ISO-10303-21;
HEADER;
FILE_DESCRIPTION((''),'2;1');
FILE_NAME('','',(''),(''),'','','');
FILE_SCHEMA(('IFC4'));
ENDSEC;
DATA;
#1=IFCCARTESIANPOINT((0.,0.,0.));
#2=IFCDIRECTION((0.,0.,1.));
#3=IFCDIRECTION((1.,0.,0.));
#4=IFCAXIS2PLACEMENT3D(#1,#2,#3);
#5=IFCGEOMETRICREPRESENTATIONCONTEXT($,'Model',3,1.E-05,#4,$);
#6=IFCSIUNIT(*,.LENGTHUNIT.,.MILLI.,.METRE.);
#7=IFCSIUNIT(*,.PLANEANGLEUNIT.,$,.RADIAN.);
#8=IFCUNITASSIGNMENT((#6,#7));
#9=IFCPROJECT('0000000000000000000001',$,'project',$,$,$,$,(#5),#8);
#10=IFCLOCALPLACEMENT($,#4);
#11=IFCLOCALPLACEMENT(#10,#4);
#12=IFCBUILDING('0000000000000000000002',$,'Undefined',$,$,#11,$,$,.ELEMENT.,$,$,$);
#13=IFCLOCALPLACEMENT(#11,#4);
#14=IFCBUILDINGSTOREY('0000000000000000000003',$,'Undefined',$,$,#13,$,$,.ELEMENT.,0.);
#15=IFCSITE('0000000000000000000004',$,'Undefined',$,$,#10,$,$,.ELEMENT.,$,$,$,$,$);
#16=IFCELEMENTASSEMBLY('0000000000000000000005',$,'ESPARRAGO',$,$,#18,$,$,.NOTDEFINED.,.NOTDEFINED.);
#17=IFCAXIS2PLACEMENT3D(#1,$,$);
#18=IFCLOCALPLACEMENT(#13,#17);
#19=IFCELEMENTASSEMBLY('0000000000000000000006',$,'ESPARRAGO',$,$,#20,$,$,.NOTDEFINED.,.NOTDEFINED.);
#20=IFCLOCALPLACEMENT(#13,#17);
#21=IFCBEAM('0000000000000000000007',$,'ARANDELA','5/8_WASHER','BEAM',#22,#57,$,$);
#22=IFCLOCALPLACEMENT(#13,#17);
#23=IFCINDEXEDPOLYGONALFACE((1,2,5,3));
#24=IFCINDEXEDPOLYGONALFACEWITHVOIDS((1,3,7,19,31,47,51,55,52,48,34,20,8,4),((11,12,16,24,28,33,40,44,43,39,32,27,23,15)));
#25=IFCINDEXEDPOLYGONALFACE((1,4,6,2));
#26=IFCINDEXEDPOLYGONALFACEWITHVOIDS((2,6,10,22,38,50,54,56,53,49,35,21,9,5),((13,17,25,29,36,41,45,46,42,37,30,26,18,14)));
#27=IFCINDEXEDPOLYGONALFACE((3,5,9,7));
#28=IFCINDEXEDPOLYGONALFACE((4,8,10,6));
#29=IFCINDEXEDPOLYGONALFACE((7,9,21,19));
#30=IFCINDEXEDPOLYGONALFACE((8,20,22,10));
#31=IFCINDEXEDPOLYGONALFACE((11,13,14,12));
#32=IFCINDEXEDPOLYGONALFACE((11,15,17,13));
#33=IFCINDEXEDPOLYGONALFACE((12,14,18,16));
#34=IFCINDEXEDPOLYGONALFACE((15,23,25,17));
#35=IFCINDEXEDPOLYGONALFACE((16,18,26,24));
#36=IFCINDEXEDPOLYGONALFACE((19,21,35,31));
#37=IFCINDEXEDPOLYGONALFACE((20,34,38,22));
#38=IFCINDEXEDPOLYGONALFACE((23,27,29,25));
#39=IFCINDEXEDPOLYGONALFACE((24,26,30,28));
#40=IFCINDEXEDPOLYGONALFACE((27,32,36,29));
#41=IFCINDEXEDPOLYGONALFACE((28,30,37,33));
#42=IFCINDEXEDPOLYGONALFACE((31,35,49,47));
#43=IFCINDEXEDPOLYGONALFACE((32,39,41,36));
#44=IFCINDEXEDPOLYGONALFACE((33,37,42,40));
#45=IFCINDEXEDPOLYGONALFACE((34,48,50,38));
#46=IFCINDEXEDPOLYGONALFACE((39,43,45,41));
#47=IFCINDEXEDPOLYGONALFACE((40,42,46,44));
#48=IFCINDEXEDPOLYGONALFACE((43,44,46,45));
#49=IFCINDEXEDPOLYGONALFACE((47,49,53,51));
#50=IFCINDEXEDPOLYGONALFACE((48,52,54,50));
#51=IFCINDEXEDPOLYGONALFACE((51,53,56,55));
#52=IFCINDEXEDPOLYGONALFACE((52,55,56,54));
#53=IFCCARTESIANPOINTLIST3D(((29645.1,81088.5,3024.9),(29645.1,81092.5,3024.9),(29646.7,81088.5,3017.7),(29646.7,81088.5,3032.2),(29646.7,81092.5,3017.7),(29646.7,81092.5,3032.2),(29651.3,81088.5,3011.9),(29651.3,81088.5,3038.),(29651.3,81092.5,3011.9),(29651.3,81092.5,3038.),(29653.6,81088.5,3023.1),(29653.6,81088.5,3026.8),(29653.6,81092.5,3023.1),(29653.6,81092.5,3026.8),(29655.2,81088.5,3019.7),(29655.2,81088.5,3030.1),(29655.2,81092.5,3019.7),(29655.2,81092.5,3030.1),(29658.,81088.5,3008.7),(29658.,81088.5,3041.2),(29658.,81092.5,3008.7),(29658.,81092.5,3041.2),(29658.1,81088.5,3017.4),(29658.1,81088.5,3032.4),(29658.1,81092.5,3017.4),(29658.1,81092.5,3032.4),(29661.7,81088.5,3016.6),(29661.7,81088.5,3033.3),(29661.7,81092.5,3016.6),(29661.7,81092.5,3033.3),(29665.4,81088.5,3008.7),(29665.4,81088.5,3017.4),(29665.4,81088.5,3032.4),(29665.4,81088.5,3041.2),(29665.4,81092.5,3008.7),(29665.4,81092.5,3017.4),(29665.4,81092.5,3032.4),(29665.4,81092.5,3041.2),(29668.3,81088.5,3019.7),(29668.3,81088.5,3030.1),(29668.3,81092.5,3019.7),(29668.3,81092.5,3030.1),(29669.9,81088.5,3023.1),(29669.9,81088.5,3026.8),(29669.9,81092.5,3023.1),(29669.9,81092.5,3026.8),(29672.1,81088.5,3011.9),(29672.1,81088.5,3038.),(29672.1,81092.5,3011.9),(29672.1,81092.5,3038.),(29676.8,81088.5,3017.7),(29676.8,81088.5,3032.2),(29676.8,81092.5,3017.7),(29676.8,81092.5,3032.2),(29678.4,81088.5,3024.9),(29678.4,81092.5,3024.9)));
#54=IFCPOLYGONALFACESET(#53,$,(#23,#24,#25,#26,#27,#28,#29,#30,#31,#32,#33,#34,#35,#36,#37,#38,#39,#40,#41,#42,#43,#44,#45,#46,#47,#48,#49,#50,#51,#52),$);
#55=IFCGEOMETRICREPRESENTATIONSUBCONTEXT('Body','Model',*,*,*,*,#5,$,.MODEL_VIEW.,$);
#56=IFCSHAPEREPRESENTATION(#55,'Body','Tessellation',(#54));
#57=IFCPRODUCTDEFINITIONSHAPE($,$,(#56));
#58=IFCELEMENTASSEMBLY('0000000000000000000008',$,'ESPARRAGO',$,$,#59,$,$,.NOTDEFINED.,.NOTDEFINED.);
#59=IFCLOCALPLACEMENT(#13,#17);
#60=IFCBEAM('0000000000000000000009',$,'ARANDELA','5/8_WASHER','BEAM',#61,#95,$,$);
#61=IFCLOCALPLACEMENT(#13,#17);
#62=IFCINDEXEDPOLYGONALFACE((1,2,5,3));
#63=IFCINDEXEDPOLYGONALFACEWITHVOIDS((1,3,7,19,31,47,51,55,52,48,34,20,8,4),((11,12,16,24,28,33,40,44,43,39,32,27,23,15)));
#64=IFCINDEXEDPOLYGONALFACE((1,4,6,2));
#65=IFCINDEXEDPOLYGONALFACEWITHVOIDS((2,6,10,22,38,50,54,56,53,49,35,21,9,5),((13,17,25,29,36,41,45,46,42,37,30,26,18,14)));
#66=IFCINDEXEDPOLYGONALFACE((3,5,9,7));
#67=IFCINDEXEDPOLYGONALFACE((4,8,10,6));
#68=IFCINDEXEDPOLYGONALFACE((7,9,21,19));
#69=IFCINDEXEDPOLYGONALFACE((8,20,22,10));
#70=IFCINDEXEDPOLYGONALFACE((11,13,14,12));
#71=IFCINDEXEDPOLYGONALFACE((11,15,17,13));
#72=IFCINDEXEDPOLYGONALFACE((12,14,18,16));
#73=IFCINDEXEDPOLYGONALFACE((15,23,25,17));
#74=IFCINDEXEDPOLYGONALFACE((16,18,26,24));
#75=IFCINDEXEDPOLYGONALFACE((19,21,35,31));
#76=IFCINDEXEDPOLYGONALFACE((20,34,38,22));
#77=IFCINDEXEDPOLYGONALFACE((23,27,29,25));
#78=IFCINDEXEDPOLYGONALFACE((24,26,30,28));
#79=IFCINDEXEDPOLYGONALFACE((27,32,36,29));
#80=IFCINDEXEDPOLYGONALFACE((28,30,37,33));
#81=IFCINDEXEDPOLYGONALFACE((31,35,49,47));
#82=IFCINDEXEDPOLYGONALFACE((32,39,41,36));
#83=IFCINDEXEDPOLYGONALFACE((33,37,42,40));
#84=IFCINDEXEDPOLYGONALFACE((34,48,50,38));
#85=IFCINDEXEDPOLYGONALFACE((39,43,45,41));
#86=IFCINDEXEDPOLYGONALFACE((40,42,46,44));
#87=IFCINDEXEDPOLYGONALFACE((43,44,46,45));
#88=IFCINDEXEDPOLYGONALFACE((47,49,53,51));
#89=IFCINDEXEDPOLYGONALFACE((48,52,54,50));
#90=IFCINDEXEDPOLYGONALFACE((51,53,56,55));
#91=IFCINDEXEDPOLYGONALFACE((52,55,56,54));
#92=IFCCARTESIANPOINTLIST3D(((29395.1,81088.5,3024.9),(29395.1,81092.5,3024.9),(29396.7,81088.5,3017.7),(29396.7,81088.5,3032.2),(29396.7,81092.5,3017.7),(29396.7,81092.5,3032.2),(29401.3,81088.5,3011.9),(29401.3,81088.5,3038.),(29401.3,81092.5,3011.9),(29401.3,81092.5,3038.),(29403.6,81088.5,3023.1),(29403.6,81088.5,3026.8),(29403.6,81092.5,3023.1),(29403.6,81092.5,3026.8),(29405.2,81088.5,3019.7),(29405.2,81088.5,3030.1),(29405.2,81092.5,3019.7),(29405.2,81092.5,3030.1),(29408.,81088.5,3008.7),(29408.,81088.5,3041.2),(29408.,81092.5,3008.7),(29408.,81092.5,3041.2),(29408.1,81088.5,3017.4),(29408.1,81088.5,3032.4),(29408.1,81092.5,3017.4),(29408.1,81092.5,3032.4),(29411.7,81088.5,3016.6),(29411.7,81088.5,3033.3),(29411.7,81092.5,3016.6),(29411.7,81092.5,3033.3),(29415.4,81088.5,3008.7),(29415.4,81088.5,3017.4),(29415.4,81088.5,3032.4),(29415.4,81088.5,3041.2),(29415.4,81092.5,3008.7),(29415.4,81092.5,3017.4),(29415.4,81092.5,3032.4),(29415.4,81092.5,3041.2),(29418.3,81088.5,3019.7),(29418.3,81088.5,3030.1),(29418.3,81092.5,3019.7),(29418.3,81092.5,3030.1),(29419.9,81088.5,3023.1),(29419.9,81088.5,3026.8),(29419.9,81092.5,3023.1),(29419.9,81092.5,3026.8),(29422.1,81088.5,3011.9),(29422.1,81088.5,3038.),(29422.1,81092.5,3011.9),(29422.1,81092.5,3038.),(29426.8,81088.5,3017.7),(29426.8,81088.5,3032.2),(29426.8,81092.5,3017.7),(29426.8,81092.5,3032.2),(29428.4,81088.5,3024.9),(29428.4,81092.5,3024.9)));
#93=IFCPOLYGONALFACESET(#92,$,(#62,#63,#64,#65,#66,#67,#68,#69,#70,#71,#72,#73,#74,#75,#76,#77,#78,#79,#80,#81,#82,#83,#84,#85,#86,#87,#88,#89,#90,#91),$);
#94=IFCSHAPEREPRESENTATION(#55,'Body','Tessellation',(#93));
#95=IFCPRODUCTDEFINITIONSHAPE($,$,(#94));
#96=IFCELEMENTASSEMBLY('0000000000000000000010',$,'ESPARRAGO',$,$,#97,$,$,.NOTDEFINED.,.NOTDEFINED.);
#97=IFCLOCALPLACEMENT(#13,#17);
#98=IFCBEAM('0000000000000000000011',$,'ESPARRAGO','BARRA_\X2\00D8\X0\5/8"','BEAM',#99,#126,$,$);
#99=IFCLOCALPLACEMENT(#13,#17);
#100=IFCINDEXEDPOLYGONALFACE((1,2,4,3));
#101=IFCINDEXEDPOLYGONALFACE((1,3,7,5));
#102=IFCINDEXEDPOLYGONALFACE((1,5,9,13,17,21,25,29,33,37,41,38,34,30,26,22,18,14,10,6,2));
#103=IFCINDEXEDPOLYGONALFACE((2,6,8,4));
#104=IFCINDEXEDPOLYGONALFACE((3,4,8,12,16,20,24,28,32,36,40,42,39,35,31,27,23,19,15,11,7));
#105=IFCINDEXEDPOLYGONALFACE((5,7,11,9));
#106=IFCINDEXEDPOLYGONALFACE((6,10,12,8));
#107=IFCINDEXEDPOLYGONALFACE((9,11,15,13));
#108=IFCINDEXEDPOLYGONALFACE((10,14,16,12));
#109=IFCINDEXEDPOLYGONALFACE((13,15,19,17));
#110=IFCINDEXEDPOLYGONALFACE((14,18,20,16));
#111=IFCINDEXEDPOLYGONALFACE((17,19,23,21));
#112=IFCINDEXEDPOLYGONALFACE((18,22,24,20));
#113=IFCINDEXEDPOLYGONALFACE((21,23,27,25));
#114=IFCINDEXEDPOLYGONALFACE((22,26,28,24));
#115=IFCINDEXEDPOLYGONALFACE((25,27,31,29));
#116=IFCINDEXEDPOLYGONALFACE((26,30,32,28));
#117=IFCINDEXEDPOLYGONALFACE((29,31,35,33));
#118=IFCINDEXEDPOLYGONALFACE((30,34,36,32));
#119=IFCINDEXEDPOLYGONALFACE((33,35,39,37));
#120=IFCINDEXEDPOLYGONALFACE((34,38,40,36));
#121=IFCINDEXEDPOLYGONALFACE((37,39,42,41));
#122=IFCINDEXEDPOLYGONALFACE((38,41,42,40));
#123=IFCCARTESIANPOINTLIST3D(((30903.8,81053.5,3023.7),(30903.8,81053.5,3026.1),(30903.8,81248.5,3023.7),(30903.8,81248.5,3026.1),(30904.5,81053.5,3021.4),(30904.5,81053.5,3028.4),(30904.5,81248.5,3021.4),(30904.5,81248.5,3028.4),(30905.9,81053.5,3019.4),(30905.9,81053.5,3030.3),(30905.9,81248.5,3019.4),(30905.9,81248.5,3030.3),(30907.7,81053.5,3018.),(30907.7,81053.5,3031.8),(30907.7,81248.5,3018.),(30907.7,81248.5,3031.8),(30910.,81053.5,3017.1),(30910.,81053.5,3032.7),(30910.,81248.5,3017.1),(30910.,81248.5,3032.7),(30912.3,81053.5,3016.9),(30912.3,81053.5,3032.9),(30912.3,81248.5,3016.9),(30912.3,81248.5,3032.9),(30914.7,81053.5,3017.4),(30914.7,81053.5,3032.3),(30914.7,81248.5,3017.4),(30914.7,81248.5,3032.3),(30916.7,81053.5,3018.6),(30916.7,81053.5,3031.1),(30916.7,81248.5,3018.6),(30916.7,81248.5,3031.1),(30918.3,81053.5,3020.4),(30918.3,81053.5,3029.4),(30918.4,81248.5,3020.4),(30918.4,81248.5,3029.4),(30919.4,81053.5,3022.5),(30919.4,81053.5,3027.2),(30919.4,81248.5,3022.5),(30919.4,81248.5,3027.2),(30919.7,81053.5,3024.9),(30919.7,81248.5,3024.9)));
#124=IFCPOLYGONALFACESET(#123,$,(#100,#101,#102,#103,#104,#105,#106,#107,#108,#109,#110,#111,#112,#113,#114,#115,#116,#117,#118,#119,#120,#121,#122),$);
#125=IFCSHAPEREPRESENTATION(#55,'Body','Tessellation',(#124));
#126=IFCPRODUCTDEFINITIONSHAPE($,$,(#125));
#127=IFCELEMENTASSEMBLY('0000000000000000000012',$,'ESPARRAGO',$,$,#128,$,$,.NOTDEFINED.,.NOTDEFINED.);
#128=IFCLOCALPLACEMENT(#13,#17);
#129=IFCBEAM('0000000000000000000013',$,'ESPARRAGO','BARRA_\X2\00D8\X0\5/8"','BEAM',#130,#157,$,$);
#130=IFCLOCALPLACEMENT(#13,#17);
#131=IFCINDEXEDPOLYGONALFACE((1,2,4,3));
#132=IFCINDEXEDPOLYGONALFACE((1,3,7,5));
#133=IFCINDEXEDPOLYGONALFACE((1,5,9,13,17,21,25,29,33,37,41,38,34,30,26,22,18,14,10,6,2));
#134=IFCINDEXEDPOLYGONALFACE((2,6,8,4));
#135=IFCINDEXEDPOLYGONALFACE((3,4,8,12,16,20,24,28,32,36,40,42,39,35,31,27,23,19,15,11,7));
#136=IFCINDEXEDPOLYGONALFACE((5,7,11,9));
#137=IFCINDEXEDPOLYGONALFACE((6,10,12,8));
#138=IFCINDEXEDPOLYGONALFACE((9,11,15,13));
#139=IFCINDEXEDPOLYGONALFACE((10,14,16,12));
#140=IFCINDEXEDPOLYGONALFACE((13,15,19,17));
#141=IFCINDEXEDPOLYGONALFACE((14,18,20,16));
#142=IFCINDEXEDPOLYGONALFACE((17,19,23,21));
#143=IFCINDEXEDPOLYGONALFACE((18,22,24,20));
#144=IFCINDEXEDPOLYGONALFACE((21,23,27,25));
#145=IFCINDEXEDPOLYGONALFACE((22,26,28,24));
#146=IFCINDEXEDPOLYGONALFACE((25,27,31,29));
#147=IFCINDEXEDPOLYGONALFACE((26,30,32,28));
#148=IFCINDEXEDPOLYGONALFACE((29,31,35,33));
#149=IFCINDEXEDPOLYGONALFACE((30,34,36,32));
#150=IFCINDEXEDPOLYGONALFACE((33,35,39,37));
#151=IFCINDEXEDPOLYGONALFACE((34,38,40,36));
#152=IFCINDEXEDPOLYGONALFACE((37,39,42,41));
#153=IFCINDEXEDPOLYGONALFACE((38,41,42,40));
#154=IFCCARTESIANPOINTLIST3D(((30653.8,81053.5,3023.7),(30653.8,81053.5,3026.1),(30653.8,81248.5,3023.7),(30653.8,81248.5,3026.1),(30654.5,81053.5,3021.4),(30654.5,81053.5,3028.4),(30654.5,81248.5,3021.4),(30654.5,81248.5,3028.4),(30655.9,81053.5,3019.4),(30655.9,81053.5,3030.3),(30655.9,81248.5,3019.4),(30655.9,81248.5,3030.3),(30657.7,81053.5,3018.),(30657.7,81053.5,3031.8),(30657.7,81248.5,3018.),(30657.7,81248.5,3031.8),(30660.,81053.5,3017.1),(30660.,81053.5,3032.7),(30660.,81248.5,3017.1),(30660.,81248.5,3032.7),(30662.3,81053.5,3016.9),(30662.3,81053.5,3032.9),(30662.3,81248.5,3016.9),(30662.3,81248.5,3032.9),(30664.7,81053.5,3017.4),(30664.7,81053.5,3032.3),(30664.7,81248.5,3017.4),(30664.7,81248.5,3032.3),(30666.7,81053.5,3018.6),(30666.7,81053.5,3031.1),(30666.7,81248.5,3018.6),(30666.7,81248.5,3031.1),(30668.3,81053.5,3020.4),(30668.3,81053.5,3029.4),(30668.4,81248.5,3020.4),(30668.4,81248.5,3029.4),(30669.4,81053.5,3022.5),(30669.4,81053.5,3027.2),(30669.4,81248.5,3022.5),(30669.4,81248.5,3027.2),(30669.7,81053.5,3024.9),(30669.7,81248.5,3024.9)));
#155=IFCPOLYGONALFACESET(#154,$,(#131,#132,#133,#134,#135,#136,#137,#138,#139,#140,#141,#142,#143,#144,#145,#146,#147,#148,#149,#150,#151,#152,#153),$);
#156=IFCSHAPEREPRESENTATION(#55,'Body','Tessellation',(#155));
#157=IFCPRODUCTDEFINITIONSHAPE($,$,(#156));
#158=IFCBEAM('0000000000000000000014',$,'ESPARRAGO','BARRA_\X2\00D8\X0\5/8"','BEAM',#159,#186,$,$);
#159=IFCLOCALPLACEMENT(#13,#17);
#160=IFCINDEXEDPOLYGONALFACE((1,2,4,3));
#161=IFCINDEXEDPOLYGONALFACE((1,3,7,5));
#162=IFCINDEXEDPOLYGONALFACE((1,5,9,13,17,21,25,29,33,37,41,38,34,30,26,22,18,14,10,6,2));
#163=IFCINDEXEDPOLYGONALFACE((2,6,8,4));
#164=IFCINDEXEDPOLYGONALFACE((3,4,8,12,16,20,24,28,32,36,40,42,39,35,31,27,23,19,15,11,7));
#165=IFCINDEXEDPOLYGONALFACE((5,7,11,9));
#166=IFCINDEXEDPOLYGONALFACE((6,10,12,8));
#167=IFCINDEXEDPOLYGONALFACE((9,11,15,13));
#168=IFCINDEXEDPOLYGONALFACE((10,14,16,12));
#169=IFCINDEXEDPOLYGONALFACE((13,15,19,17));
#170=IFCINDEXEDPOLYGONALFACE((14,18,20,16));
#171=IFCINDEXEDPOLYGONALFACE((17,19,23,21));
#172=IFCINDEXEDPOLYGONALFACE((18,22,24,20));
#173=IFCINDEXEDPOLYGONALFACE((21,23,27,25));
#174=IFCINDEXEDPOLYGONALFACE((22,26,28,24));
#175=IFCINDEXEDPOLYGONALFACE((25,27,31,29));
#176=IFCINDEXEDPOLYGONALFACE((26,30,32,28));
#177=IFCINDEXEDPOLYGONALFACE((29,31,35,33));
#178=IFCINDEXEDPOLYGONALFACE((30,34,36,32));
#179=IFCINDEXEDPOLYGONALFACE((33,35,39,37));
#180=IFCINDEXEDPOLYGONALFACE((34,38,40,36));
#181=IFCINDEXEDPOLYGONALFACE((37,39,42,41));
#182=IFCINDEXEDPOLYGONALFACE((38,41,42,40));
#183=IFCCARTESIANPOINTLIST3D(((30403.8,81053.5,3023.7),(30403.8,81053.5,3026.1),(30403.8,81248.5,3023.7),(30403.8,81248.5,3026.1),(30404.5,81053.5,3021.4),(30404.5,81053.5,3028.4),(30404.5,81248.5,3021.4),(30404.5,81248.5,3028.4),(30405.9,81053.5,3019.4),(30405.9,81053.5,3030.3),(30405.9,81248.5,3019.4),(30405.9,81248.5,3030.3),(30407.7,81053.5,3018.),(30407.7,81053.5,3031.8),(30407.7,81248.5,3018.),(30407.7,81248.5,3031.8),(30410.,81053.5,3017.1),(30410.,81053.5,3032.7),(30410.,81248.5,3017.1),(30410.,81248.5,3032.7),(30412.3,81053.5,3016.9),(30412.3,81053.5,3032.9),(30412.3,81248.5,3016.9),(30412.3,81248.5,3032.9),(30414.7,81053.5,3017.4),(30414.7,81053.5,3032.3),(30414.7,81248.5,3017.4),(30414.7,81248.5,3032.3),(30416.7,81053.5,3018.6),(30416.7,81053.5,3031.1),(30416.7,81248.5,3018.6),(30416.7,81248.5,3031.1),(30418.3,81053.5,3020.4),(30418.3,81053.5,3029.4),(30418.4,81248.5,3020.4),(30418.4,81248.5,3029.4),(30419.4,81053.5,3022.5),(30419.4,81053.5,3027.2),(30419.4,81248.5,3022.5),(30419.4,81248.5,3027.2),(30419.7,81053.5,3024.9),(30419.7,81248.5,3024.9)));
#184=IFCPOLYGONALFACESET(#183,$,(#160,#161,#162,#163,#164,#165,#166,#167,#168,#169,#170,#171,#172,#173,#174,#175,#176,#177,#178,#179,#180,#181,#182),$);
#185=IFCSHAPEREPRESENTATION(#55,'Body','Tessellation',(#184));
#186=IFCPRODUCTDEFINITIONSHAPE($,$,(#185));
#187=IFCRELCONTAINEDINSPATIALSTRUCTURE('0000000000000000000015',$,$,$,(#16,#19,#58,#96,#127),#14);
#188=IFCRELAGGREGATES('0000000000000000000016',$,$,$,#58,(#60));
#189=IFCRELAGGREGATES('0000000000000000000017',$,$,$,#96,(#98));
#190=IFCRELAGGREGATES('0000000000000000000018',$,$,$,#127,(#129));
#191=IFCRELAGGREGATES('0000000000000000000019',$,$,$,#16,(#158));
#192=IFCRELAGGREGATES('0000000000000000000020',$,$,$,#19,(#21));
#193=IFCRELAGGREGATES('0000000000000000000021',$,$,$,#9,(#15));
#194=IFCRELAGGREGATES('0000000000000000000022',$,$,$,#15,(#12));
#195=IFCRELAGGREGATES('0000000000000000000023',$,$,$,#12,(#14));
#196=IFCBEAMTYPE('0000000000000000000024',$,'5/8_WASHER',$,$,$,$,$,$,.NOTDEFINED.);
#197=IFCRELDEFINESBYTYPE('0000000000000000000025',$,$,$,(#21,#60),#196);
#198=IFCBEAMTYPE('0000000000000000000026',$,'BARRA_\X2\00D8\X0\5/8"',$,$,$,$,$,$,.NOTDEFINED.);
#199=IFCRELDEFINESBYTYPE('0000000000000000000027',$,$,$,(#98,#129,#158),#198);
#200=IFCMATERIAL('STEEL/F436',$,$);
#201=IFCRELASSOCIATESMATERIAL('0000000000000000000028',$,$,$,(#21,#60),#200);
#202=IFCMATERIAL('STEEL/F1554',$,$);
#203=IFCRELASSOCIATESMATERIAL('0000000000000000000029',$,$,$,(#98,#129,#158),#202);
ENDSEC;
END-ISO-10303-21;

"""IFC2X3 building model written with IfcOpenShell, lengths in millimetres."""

from ifc_helpers import new_model, si_unit, frame, origin_with_axes, origin_2d_with_axis, place, context, subcontext, project, spatial, polyline, circle, outline, extrude, material, type_object, element, aggregate, save


model = new_model("IFC2X3")

# Units and contexts
model_context = context("Model", 3, precision=1e-05, world=origin_with_axes())
body_context = subcontext(model_context, "Body", "Model", "MODEL_VIEW")
ifc_project = project(units=[si_unit("LENGTHUNIT", "METRE", prefix="MILLI"), si_unit("PLANEANGLEUNIT", "RADIAN")], contexts=[model_context])

# Site, building, storey
site_placement = place(None, origin_with_axes())
site = spatial("IfcSite", under=ifc_project, at=site_placement, Name="Undefined", CompositionType="ELEMENT")
building_placement = place(site_placement, origin_with_axes())
building = spatial("IfcBuilding", under=site, at=building_placement, Name="Undefined", CompositionType="ELEMENT")
storey_placement = place(building_placement, origin_with_axes())
storey = spatial("IfcBuildingStorey", under=building, at=storey_placement, Name="Undefined", CompositionType="ELEMENT", Elevation=0.0)

# Element assemblies, beams
assembly_1_placement = place(storey_placement, origin_with_axes())
assembly_1 = element("IfcElementAssembly", 1, at=assembly_1_placement, inside=storey, Name="ESPARRAGO", AssemblyPlace="NOTDEFINED", PredefinedType="NOTDEFINED")
ifc_material_1 = material(Name="STEEL/F436")
beam_type_1 = type_object("IfcBeamType", Name="5/8_WASHER", PredefinedType="NOTDEFINED")
assembly_2_placement = place(storey_placement, origin_with_axes())
assembly_2 = element("IfcElementAssembly", 2, at=assembly_2_placement, inside=storey, Name="ESPARRAGO", AssemblyPlace="NOTDEFINED", PredefinedType="NOTDEFINED")
beam_1_placement = place(assembly_2_placement, frame((29661.7, 81088.5, 3024.9), z_axis=(0.0, 0.000086, 1.0), x_axis=(0.000015, 1.0, -0.000086)))
beam_1 = element("IfcBeam", 3, at=beam_1_placement, type_object=beam_type_1, material=ifc_material_1, Name="ARANDELA", Description="5/8_WASHER", ObjectType="BEAM", context=body_context, shape_type="SweptSolid", body=[
    extrude(outline(polyline([(10.4, 13.0), (15.0, 7.2), (16.7, 0.0), (15.0, -7.2), (10.4, -13.0), (3.7, -16.3), (-3.7, -16.3), (-10.4, -13.0), (-15.0, -7.2), (-16.7, 0.0), (-15.0, 7.2), (-10.4, 13.0), (-3.7, 16.3), (3.7, 16.3), (10.4, 13.0)]), holes=[polyline([(6.5, -5.2), (8.1, -1.9), (8.1, 1.9), (6.5, 5.2), (3.6, 7.5), (0.0, 8.3), (-3.6, 7.5), (-6.5, 5.2), (-8.1, 1.9), (-8.1, -1.9), (-6.5, -5.2), (-3.6, -7.5), (0.0, -8.3), (3.6, -7.5), (6.5, -5.2)])]), frame((4.0, 0.0, 0.0), z_axis=(-1.0, 0.0, 0.0), x_axis=(0.0, -1.0, 0.0)), (0.0, 0.0, 1.0), 4.0),
])
assembly_3_placement = place(storey_placement, origin_with_axes())
assembly_3 = element("IfcElementAssembly", 4, at=assembly_3_placement, inside=storey, Name="ESPARRAGO", AssemblyPlace="NOTDEFINED", PredefinedType="NOTDEFINED")
beam_2_placement = place(assembly_3_placement, frame((29411.7, 81088.5, 3024.9), z_axis=(0.0, 0.000086, 1.0), x_axis=(0.000015, 1.0, -0.000086)))
beam_2 = element("IfcBeam", 5, at=beam_2_placement, type_object=beam_type_1, material=ifc_material_1, Name="ARANDELA", Description="5/8_WASHER", ObjectType="BEAM", context=body_context, shape_type="SweptSolid", body=[
    extrude(outline(polyline([(10.4, 13.0), (15.0, 7.2), (16.7, 0.0), (15.0, -7.2), (10.4, -13.0), (3.7, -16.3), (-3.7, -16.3), (-10.4, -13.0), (-15.0, -7.2), (-16.7, 0.0), (-15.0, 7.2), (-10.4, 13.0), (-3.7, 16.3), (3.7, 16.3), (10.4, 13.0)]), holes=[polyline([(6.5, -5.2), (8.1, -1.9), (8.1, 1.9), (6.5, 5.2), (3.6, 7.5), (0.0, 8.3), (-3.6, 7.5), (-6.5, 5.2), (-8.1, 1.9), (-8.1, -1.9), (-6.5, -5.2), (-3.6, -7.5), (0.0, -8.3), (3.6, -7.5), (6.5, -5.2)])]), frame((4.0, 0.0, 0.0), z_axis=(-1.0, 0.0, 0.0), x_axis=(0.0, -1.0, 0.0)), (0.0, 0.0, 1.0), 4.0),
])
aggregate(assembly_3, [beam_2])
assembly_4_placement = place(storey_placement, origin_with_axes())
assembly_4 = element("IfcElementAssembly", 6, at=assembly_4_placement, inside=storey, Name="ESPARRAGO", AssemblyPlace="NOTDEFINED", PredefinedType="NOTDEFINED")
ifc_material_2 = material(Name="STEEL/F1554")
beam_type_2 = type_object("IfcBeamType", Name="BARRA_Ø5/8\"", PredefinedType="NOTDEFINED")
beam_3_placement = place(assembly_4_placement, frame((30911.7, 81053.5, 3024.9), z_axis=(0.0, 0.0, 1.0), x_axis=(0.000021, 1.0, 0.0)))
beam_3 = element("IfcBeam", 7, at=beam_3_placement, type_object=beam_type_2, material=ifc_material_2, Name="ESPARRAGO", Description="BARRA_Ø5/8\"", ObjectType="BEAM", context=body_context, shape_type="SweptSolid", body=[
    extrude(circle(Radius=8.0, at=origin_2d_with_axis()), frame((195.0, 0.0, 0.0), z_axis=(-1.0, 0.0, 0.0), x_axis=(0.0, -1.0, 0.0)), (0.0, 0.0, 1.0), 195.0),
])
aggregate(assembly_4, [beam_3])
assembly_5_placement = place(storey_placement, origin_with_axes())
assembly_5 = element("IfcElementAssembly", 8, at=assembly_5_placement, inside=storey, Name="ESPARRAGO", AssemblyPlace="NOTDEFINED", PredefinedType="NOTDEFINED")
beam_4_placement = place(assembly_5_placement, frame((30661.7, 81053.5, 3024.9), z_axis=(0.0, 0.0, 1.0), x_axis=(0.000021, 1.0, 0.0)))
beam_4 = element("IfcBeam", 9, at=beam_4_placement, type_object=beam_type_2, material=ifc_material_2, Name="ESPARRAGO", Description="BARRA_Ø5/8\"", ObjectType="BEAM", context=body_context, shape_type="SweptSolid", body=[
    extrude(circle(Radius=8.0, at=origin_2d_with_axis()), frame((195.0, 0.0, 0.0), z_axis=(-1.0, 0.0, 0.0), x_axis=(0.0, -1.0, 0.0)), (0.0, 0.0, 1.0), 195.0),
])
aggregate(assembly_5, [beam_4])

# Beam
beam_5_placement = place(assembly_1_placement, frame((30411.7, 81053.5, 3024.9), z_axis=(0.0, 0.0, 1.0), x_axis=(0.000021, 1.0, 0.0)))
beam_5 = element("IfcBeam", 10, at=beam_5_placement, type_object=beam_type_2, material=ifc_material_2, Name="ESPARRAGO", Description="BARRA_Ø5/8\"", ObjectType="BEAM", context=body_context, shape_type="SweptSolid", body=[
    extrude(circle(Radius=8.0, at=origin_2d_with_axis()), frame((195.0, 0.0, 0.0), z_axis=(-1.0, 0.0, 0.0), x_axis=(0.0, -1.0, 0.0)), (0.0, 0.0, 1.0), 195.0),
])
aggregate(assembly_1, [beam_5])
aggregate(assembly_2, [beam_1])

save(model, "model.ifc")
